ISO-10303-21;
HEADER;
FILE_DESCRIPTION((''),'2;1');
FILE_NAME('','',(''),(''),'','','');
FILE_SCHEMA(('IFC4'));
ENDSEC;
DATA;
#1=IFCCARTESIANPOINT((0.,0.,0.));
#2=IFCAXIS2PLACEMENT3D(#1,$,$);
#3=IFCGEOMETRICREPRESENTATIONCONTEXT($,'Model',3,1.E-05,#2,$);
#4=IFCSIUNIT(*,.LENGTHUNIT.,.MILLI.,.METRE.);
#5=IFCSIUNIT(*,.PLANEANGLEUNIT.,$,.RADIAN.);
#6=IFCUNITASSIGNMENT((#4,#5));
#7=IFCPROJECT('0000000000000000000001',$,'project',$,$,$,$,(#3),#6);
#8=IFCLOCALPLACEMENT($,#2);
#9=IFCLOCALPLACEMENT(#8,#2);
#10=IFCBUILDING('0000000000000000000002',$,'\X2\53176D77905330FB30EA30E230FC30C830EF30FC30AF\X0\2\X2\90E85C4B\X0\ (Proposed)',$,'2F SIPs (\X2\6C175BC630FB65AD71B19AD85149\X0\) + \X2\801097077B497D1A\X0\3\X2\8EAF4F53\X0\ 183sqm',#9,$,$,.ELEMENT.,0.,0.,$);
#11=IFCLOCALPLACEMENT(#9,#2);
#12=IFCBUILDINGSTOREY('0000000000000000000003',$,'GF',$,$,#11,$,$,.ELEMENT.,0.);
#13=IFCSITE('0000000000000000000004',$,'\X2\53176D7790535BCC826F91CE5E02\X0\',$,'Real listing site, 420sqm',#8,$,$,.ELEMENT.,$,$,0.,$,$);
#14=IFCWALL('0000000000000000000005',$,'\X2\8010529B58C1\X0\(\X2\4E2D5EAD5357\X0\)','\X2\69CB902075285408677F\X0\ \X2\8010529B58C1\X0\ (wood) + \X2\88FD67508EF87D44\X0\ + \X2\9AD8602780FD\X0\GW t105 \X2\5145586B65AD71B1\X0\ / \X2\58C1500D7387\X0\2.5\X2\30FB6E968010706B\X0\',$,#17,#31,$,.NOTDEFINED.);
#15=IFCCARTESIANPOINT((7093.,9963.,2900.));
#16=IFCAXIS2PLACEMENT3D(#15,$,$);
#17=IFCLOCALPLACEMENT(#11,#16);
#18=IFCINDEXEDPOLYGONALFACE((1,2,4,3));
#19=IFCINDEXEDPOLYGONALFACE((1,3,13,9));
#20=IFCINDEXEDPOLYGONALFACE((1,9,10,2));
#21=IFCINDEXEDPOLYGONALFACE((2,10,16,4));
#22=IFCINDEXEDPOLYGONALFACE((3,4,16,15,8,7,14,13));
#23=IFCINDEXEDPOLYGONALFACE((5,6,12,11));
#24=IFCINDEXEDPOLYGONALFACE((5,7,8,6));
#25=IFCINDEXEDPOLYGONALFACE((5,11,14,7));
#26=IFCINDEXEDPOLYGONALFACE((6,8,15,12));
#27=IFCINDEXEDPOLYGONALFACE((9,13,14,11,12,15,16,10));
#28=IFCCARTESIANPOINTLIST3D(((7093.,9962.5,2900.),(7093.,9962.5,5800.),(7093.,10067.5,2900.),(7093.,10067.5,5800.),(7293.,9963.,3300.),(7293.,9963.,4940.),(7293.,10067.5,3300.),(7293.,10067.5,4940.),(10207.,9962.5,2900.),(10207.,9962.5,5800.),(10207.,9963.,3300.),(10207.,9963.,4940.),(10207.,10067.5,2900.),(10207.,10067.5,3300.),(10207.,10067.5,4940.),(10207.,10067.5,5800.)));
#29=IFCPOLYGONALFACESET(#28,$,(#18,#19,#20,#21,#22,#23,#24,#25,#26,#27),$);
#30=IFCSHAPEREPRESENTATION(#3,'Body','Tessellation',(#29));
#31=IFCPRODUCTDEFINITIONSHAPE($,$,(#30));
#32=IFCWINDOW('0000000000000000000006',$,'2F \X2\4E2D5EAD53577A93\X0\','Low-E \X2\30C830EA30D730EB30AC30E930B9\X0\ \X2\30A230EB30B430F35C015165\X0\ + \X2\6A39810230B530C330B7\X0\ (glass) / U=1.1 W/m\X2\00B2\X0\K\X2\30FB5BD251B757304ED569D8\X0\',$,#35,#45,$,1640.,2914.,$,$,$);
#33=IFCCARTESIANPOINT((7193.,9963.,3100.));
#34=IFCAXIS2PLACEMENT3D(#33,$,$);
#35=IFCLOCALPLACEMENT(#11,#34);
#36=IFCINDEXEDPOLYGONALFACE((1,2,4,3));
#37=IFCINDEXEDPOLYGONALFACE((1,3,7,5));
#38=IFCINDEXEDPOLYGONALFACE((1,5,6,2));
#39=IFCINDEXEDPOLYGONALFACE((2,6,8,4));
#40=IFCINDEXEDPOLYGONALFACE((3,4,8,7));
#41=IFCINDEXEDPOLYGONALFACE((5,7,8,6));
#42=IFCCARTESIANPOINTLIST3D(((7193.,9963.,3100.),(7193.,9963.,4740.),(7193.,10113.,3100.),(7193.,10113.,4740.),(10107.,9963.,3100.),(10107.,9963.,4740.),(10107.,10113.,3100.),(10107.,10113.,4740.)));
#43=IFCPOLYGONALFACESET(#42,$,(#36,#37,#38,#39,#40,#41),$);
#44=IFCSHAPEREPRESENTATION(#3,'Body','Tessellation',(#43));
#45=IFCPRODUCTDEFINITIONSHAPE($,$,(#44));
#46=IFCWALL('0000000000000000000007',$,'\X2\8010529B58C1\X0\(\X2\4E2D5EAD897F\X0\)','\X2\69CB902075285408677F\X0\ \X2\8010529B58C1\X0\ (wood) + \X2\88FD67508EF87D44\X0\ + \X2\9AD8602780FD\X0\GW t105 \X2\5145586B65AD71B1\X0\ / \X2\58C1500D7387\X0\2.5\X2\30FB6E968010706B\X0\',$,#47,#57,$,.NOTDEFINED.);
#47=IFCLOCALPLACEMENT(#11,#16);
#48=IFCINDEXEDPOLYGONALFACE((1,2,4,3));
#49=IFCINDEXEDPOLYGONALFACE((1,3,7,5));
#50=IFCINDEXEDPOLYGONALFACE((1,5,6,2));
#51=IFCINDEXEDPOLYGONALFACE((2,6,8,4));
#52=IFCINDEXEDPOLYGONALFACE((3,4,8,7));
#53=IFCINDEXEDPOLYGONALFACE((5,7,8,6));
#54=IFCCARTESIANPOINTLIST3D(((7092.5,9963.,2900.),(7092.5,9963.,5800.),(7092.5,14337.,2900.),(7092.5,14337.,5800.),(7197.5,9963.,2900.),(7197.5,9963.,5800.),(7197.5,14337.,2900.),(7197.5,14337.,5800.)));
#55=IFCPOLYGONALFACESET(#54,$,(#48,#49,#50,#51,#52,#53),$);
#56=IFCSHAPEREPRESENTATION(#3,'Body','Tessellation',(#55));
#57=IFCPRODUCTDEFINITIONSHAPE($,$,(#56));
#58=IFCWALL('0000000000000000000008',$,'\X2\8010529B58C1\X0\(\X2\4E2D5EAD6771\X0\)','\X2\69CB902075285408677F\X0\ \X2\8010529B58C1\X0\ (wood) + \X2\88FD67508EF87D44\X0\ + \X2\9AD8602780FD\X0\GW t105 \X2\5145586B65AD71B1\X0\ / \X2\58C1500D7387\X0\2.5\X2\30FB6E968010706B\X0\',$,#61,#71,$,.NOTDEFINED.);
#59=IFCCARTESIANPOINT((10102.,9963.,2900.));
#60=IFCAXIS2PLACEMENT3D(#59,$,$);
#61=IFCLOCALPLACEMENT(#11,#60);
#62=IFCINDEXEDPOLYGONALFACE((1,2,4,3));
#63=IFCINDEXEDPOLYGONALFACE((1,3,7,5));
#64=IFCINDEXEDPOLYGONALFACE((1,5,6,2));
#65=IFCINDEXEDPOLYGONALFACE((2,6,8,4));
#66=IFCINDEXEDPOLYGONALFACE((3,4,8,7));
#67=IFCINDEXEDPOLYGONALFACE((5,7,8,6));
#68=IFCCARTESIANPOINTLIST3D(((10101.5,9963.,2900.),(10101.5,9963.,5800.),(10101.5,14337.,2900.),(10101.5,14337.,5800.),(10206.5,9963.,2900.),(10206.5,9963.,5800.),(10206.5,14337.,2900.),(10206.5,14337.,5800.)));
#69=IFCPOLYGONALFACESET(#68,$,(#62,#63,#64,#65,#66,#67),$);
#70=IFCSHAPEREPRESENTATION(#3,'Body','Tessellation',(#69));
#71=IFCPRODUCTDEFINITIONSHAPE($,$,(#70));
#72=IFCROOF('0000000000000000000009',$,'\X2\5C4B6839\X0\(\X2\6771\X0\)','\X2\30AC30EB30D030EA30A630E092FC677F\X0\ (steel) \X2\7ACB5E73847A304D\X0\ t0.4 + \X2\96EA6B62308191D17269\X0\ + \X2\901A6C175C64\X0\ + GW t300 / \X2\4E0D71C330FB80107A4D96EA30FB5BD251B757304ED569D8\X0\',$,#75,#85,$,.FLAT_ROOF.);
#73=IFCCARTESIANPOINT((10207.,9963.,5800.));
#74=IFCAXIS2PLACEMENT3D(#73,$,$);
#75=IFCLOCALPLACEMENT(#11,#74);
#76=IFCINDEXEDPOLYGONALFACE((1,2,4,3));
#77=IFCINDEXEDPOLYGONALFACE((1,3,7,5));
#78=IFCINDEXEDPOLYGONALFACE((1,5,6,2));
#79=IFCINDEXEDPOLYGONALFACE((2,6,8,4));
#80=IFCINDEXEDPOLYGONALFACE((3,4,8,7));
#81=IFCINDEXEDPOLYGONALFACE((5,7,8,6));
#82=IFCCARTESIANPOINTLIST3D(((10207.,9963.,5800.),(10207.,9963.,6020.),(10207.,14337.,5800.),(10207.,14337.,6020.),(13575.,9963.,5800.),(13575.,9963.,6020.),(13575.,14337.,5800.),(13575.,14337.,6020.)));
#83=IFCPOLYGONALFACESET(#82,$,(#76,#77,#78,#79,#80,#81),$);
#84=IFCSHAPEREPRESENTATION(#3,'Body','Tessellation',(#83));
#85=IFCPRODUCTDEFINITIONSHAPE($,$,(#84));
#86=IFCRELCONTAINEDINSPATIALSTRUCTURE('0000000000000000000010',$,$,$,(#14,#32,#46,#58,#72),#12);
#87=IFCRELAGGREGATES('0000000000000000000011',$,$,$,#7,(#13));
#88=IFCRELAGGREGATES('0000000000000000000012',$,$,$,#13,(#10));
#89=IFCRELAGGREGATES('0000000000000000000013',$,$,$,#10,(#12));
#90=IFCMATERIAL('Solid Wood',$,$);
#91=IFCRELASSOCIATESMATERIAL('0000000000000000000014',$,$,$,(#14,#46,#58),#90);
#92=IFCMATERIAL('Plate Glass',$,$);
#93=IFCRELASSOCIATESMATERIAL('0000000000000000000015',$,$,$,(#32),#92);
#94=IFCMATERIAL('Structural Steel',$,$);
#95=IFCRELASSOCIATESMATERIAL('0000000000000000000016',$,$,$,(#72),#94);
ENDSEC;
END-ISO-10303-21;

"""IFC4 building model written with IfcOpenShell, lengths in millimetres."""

from ifc_helpers import new_model, si_unit, frame, frame_2d, origin, place, context, project, spatial, rectangle, extrude, material, element, fill, save


model = new_model("IFC4")

# Units and contexts
model_context = context("Model", 3, precision=1e-05, world=origin())
ifc_project = project(units=[si_unit("LENGTHUNIT", "METRE", prefix="MILLI"), si_unit("PLANEANGLEUNIT", "RADIAN")], contexts=[model_context])

# Site, building, storey
site_placement = place(None, origin())
site = spatial("IfcSite", under=ifc_project, at=site_placement, Name="北海道富良野市", ObjectType="Real listing site, 420sqm", CompositionType="ELEMENT", RefElevation=0.0)
building_placement = place(site_placement, origin())
building = spatial("IfcBuilding", under=site, at=building_placement, Name="北海道・リモートワーク2部屋 (Proposed)", ObjectType="2F SIPs (気密・断熱高光) + 耐震等級3躯体 183sqm", CompositionType="ELEMENT", ElevationOfRefHeight=0.0, ElevationOfTerrain=0.0)
storey_placement = place(building_placement, origin())
storey = spatial("IfcBuildingStorey", under=building, at=storey_placement, Name="GF", CompositionType="ELEMENT", Elevation=0.0)

# Shared definitions
ifc_material_1 = material(Name="Solid Wood")

# Shared definitions
ifc_material_2 = material(Name="Plate Glass")

# Wall, opening, window
wall_1_placement = place(storey_placement, frame((7093.0, 9963.0, 2900.0)))
wall_1 = element("IfcWall", 1, at=wall_1_placement, inside=storey, material=ifc_material_1, Name="耐力壁(中庭南)", Description="構造用合板 耐力壁 (wood) + 製材軸組 + 高性能GW t105 充填断熱 / 壁倍率2.5・準耐火", PredefinedType="NOTDEFINED", context=model_context, shape_type="SweptSolid", body=[
    extrude(rectangle(XDim=3114.0, YDim=105.0, at=frame_2d((1557.0, 52.0))), frame((7093.0, 9963.0, 2900.0)), (0.0, 0.0, 1.0), 2900.0),
])
opening_1_placement = place(storey_placement, frame((7193.0, 9963.0, 3100.0)))
opening_1 = element("IfcOpeningElement", 2, at=opening_1_placement, cuts=wall_1, PredefinedType="NOTDEFINED", context=model_context, shape_type="SweptSolid", body=[
    extrude(rectangle(XDim=2914.0, YDim=150.0, at=frame_2d((1457.0, 75.0))), frame((7193.0, 9963.0, 3100.0)), (0.0, 0.0, 1.0), 1640.0),
])
window_1_placement = place(storey_placement, frame((7193.0, 9963.0, 3100.0)))
window_1 = element("IfcWindow", 3, at=window_1_placement, inside=storey, material=ifc_material_2, Name="2F 中庭南窓", Description="Low-E トリプルガラス アルゴン封入 + 樹脂サッシ (glass) / U=1.1 W/m²K・寒冷地仕様", OverallHeight=1640.0, OverallWidth=2914.0, context=model_context, shape_type="SweptSolid", body=[
    extrude(rectangle(XDim=2914.0, YDim=150.0, at=frame_2d((1457.0, 75.0))), frame((7193.0, 9963.0, 3100.0)), (0.0, 0.0, 1.0), 1640.0),
])
fill(opening_1, window_1)

# Walls
wall_2_placement = place(storey_placement, frame((7093.0, 9963.0, 2900.0)))
element("IfcWall", 4, at=wall_2_placement, inside=storey, material=ifc_material_1, Name="耐力壁(中庭西)", Description="構造用合板 耐力壁 (wood) + 製材軸組 + 高性能GW t105 充填断熱 / 壁倍率2.5・準耐火", PredefinedType="NOTDEFINED", context=model_context, shape_type="SweptSolid", body=[
    extrude(rectangle(XDim=105.0, YDim=4374.0, at=frame_2d((52.0, 2187.0))), frame((7093.0, 9963.0, 2900.0)), (0.0, 0.0, 1.0), 2900.0),
])
wall_3_placement = place(storey_placement, frame((10102.0, 9963.0, 2900.0)))
element("IfcWall", 5, at=wall_3_placement, inside=storey, material=ifc_material_1, Name="耐力壁(中庭東)", Description="構造用合板 耐力壁 (wood) + 製材軸組 + 高性能GW t105 充填断熱 / 壁倍率2.5・準耐火", PredefinedType="NOTDEFINED", context=model_context, shape_type="SweptSolid", body=[
    extrude(rectangle(XDim=105.0, YDim=4374.0, at=frame_2d((52.0, 2187.0))), frame((10102.0, 9963.0, 2900.0)), (0.0, 0.0, 1.0), 2900.0),
])

# Roof
ifc_material_3 = material(Name="Structural Steel")
for number, where, name in (
    (6, (10207.0, 9963.0, 5800.0), "屋根(東)"),
):
    element("IfcRoof", number, at=place(storey_placement, frame(where)), inside=storey, material=ifc_material_3, Name=name, Description="ガルバリウム鋼板 (steel) 立平葺き t0.4 + 雪止め金物 + 通気層 + GW t300 / 不燃・耐積雪・寒冷地仕様", PredefinedType="FLAT_ROOF", context=model_context, shape_type="SweptSolid", body=[
        extrude(rectangle(XDim=3368.0, YDim=4374.0, at=frame_2d((1684.0, 2187.0))), frame((10207.0, 9963.0, 5800.0)), (0.0, 0.0, 1.0), 220.0),
    ])

save(model, "model.ifc")
